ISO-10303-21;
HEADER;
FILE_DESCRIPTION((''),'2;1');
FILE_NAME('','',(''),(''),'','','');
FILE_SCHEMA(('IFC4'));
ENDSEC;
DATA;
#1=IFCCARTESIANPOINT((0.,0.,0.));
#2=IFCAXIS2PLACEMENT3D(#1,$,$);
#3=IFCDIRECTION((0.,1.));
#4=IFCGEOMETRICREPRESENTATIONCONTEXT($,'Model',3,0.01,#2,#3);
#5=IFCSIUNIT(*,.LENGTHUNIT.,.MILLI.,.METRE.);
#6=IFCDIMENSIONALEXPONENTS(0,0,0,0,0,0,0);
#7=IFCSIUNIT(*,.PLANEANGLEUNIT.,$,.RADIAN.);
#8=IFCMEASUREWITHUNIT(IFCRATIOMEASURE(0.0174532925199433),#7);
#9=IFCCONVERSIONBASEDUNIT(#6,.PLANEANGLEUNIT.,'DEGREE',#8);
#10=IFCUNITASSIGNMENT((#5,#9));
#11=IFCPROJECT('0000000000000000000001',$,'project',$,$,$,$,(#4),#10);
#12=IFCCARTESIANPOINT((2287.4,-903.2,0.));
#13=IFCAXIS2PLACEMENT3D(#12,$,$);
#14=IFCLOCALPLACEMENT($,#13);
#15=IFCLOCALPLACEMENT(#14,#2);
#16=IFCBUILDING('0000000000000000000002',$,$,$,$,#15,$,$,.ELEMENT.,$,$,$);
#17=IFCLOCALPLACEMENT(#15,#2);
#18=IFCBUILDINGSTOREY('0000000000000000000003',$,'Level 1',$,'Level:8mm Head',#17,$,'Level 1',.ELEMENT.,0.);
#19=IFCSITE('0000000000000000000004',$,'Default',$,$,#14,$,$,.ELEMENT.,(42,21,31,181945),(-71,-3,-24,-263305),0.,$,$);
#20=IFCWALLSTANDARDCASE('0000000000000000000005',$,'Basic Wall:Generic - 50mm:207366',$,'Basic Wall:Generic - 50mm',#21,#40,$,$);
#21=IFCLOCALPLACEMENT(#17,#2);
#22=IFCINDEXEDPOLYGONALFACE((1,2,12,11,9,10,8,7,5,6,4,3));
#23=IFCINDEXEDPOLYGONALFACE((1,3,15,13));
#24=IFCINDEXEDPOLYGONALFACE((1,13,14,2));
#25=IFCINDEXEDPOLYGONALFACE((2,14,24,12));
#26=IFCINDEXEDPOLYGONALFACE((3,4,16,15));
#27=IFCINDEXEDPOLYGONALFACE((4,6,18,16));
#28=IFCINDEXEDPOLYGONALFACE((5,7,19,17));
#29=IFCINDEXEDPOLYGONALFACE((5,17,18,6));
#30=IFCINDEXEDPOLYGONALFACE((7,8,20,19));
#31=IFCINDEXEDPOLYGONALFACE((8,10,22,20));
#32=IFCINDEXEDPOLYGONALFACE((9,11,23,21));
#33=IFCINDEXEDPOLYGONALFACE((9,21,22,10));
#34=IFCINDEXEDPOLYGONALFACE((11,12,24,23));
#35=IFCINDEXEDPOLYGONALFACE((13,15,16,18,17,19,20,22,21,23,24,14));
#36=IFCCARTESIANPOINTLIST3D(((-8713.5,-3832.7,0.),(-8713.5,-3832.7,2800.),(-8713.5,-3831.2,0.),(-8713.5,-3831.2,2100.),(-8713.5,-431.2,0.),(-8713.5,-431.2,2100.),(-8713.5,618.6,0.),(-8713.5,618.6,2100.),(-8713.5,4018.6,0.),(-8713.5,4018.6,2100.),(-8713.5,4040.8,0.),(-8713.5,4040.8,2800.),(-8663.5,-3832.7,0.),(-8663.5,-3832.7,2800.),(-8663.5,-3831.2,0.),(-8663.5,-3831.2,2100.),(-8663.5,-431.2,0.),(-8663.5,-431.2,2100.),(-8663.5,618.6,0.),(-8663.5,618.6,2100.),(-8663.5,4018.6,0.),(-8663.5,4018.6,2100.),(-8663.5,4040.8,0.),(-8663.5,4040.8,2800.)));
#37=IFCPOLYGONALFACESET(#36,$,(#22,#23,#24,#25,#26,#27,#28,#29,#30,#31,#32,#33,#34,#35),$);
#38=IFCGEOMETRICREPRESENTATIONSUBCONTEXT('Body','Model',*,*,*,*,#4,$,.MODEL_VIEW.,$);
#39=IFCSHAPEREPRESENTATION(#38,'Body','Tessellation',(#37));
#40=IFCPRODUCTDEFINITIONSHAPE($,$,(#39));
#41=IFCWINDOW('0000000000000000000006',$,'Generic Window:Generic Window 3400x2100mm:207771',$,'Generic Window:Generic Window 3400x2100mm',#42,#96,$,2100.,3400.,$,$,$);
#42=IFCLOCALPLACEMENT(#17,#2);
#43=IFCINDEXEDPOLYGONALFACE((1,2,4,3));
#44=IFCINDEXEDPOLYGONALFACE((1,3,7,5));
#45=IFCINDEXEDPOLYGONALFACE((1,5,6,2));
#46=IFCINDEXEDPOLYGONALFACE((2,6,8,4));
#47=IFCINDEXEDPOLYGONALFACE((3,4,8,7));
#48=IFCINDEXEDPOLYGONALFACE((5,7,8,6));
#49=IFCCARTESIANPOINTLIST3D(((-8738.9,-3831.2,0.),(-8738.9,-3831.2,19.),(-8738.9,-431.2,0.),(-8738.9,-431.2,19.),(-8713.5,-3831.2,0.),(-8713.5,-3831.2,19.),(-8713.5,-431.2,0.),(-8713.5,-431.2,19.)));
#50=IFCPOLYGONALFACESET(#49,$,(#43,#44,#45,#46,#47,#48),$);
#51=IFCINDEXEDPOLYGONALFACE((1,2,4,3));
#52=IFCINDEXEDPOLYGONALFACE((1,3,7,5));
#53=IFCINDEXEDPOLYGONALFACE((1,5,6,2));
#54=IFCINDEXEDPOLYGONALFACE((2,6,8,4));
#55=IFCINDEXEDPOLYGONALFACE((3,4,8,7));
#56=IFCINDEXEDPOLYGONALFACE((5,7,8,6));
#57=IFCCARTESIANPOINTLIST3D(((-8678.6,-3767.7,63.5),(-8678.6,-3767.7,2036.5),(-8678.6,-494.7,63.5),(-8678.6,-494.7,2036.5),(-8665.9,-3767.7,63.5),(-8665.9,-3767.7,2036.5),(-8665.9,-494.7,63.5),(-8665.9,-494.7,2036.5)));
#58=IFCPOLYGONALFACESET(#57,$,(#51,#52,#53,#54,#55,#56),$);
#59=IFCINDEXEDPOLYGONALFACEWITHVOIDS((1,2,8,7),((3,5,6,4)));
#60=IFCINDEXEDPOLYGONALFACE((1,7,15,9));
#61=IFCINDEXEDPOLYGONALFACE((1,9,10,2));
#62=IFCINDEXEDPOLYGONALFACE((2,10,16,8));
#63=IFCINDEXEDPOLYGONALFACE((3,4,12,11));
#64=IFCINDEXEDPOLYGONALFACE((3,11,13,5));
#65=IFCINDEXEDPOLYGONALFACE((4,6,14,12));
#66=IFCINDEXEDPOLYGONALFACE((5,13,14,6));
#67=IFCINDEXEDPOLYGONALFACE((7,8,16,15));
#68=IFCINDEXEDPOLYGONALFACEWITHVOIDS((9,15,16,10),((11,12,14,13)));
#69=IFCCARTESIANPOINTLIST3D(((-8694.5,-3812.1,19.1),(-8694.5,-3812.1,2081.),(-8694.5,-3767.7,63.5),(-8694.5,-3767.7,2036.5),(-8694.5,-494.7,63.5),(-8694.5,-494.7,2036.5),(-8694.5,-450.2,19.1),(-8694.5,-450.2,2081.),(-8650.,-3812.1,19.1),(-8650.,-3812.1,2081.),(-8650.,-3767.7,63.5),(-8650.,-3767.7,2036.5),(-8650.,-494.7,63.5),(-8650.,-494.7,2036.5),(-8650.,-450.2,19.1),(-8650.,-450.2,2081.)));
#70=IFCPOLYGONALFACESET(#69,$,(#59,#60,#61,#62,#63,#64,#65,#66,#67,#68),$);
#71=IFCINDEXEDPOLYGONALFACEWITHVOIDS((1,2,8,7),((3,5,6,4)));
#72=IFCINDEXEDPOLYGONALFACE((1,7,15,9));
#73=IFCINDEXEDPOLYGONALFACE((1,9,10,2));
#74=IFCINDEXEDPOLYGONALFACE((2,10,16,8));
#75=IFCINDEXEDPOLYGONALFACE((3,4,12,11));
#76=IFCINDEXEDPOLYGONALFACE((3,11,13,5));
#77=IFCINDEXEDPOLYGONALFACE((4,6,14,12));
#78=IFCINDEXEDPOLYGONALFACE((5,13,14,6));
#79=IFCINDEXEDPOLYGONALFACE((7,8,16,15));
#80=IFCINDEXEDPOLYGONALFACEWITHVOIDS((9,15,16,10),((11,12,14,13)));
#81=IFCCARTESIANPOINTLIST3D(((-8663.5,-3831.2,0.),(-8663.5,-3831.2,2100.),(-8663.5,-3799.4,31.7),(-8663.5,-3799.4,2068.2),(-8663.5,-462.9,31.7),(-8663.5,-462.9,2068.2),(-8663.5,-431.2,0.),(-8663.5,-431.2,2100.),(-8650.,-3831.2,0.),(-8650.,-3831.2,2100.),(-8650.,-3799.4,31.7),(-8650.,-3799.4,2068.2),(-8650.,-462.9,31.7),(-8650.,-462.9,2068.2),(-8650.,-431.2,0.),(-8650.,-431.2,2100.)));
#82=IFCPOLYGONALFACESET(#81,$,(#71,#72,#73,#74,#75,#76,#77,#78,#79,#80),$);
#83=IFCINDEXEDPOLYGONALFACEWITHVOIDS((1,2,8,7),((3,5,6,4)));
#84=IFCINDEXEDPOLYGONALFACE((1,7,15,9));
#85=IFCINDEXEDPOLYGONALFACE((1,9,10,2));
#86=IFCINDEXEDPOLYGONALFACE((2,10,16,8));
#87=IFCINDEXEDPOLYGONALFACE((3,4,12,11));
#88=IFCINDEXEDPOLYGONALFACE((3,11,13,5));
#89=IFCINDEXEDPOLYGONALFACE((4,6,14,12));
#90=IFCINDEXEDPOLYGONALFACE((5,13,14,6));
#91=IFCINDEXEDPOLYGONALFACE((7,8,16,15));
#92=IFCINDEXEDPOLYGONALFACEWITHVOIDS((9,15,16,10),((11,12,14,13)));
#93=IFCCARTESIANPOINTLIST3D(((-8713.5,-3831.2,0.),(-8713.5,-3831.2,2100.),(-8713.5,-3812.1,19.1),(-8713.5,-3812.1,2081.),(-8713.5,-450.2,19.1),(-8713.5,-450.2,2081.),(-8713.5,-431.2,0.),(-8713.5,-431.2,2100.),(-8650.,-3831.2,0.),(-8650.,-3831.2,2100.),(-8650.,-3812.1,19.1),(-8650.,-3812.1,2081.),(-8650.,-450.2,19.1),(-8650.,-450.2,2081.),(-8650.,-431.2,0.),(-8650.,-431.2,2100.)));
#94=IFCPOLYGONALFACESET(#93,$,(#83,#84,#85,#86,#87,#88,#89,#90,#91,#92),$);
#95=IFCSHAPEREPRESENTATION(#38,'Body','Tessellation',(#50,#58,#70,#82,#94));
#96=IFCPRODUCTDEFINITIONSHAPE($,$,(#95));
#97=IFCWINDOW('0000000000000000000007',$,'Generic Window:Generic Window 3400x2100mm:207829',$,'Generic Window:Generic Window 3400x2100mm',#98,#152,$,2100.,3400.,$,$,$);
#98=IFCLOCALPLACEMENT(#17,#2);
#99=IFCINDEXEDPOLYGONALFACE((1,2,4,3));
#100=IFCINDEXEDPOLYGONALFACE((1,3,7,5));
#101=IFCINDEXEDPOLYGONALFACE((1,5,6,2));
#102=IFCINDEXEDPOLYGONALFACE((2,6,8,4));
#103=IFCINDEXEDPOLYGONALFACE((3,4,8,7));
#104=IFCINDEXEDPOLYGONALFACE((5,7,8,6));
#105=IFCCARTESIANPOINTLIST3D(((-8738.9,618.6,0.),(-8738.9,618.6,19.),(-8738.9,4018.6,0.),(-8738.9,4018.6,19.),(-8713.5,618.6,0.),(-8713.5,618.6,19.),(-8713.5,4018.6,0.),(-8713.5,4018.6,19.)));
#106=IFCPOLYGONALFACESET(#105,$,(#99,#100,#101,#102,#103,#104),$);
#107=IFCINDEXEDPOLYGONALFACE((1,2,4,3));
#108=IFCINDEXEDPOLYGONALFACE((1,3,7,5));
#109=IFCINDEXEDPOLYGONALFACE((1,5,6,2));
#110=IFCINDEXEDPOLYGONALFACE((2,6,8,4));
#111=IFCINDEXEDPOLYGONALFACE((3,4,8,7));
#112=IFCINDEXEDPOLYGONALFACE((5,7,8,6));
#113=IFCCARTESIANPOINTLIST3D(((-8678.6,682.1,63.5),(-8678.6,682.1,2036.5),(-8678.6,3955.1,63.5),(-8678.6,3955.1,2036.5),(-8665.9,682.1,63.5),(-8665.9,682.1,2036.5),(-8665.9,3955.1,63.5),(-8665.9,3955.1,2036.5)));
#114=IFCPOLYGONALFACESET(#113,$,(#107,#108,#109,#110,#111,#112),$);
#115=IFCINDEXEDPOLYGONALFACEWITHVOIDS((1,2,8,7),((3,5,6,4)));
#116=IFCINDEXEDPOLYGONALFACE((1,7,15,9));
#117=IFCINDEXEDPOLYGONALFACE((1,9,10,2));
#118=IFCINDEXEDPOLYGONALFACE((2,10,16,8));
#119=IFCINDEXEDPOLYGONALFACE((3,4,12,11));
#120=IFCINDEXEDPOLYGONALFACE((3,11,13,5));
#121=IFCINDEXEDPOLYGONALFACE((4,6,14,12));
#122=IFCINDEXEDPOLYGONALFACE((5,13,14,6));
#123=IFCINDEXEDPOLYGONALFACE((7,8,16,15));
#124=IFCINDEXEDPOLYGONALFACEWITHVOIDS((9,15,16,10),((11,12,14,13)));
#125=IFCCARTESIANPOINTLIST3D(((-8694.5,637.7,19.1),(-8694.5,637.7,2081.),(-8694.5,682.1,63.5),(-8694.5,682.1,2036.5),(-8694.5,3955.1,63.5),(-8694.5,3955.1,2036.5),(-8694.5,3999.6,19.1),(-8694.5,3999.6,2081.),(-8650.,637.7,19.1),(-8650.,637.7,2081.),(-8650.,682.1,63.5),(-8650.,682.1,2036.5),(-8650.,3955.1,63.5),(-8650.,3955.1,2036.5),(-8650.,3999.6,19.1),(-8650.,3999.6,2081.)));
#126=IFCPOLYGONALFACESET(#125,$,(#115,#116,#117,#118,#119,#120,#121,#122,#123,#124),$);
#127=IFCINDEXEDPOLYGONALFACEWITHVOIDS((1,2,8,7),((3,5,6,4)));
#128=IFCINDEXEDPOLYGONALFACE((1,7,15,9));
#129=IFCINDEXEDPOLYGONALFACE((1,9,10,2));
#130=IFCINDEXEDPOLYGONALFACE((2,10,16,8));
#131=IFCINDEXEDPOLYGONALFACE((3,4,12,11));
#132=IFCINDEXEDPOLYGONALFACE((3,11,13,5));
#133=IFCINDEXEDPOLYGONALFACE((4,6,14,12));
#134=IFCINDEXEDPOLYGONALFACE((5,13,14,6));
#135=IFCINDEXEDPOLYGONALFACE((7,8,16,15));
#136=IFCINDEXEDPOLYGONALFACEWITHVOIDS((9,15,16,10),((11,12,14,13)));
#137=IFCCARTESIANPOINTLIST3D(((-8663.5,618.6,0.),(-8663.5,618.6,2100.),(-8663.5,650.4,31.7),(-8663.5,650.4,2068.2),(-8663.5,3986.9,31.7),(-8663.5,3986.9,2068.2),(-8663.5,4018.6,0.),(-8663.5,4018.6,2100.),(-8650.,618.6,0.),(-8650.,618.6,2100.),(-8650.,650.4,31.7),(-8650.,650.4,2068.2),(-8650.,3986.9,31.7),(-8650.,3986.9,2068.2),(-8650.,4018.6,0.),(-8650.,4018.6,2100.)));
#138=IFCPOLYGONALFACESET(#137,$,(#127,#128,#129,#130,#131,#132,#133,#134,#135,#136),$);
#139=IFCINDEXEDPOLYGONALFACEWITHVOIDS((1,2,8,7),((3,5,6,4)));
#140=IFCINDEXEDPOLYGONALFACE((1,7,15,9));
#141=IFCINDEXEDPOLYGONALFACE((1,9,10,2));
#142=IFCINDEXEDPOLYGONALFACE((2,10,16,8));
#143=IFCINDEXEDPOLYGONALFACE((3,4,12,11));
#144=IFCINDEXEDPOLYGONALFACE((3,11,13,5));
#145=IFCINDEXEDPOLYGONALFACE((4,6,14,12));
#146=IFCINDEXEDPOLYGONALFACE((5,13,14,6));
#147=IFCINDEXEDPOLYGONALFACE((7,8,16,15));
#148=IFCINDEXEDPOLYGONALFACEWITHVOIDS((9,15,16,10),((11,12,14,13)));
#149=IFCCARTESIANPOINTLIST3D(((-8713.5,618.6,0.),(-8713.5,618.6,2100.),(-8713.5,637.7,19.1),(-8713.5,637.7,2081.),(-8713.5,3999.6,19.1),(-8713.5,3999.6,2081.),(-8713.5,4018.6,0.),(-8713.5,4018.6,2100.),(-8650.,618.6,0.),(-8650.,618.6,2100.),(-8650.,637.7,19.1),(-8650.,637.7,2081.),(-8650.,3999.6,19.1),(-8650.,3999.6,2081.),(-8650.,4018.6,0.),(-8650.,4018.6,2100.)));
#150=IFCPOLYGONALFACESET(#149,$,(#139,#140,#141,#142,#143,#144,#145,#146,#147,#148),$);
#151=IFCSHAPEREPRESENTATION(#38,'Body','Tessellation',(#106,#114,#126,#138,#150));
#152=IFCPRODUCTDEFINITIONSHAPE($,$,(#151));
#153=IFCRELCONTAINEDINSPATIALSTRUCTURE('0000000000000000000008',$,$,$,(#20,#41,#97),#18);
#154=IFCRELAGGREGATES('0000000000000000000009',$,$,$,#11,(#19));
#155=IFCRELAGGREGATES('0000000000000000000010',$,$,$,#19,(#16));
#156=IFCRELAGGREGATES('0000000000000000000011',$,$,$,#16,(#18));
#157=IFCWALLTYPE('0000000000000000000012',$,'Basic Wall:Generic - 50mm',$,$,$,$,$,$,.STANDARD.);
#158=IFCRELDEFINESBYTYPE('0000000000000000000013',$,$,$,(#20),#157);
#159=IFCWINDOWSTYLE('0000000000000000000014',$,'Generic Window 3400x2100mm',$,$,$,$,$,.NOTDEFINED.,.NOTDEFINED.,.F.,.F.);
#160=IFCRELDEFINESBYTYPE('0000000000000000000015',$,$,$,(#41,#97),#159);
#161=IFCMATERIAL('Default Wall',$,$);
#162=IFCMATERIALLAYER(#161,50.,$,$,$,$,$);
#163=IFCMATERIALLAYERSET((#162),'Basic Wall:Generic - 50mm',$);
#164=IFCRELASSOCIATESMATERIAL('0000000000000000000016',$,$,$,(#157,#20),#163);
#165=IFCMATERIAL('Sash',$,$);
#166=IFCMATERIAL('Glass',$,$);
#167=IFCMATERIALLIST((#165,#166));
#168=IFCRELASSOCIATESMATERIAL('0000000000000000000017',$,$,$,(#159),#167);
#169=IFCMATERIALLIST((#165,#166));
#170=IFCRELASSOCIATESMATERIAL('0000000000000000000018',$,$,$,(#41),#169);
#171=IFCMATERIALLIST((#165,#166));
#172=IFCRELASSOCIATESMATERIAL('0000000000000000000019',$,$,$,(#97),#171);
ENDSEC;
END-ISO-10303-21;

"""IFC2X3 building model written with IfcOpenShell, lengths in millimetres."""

from ifc_helpers import new_model, entity, si_unit, converted_unit, direction, frame, frame_2d, origin, origin_2d_with_axis, place, context, subcontext, project, spatial, polyline, rectangle, outline, extrude, source, transform, mapped, material, material_list, layer, layer_set, layer_usage, type_object, type_shapes, element, fill, save


model = new_model("IFC2X3")

# Units and contexts
model_context = context("Model", 3, precision=0.01, world=origin(), true_north=direction((0.0, 1.0)))
body_context = subcontext(model_context, "Body", "Model", "MODEL_VIEW")
ifc_project = project(units=[si_unit("LENGTHUNIT", "METRE", prefix="MILLI"), converted_unit("PLANEANGLEUNIT", "DEGREE", entity("IfcRatioMeasure", 0.0174532925199433), si_unit("PLANEANGLEUNIT", "RADIAN"), dimensions=[0, 0, 0, 0, 0, 0, 0])], contexts=[model_context])

# Site, building, storey
site_placement = place(None, frame((2287.4, -903.2, 0.0)))
site = spatial("IfcSite", under=ifc_project, at=site_placement, Name="Default", CompositionType="ELEMENT", RefLatitude=(42, 21, 31, 181945), RefLongitude=(-71, -3, -24, -263305), RefElevation=0.0)
building_placement = place(site_placement, origin())
building = spatial("IfcBuilding", under=site, at=building_placement, CompositionType="ELEMENT")
storey_placement = place(building_placement, origin())
storey = spatial("IfcBuildingStorey", under=building, at=storey_placement, Name="Level 1", ObjectType="Level:8mm Head", LongName="Level 1", CompositionType="ELEMENT", Elevation=0.0)

# Shared definitions
ifc_material_1 = material(Name="Default Wall")
ifc_layer = layer(ifc_material_1, 50.0)
ifc_layer_set = layer_set([ifc_layer], Name="Basic Wall:Generic - 50mm")
wall_type = type_object("IfcWallType", Name="Basic Wall:Generic - 50mm", PredefinedType="STANDARD", material=ifc_layer_set)

# Wall, openings, windows
ifc_layer_usage_1 = layer_usage(ifc_layer_set, "AXIS2", "POSITIVE", -25.0)
wall_1_placement = place(storey_placement, frame((-8688.5, 4040.8, 0.0), z_axis=(0.0, 0.0, 1.0), x_axis=(0.0, -1.0, 0.0)))
wall_1 = element("IfcWallStandardCase", 1, at=wall_1_placement, inside=storey, type_object=wall_type, material=ifc_layer_usage_1, Name="Basic Wall:Generic - 50mm:207366", ObjectType="Basic Wall:Generic - 50mm", context=body_context, shape_type="SweptSolid", body=[
    extrude(rectangle(XDim=7873.5, YDim=50.0, at=frame_2d((3936.8, 0.0), x_axis=(-1.0, 0.0))), origin(), (0.0, 0.0, 1.0), 2800.0),
])
opening_1_placement = place(wall_1_placement, frame((7872.0, 25.0, 0.0)))
opening_1 = element("IfcOpeningElement", 2, at=opening_1_placement, cuts=wall_1, ObjectType="Opening", context=body_context, shape_type="SweptSolid", body=[
    extrude(rectangle(XDim=2100.0, YDim=3400.0, at=frame_2d((1050.0, 1700.0), x_axis=(-1.0, 0.0))), frame((0.0, 0.0, 0.0), z_axis=(0.0, -1.0, 0.0), x_axis=(0.0, 0.0, 1.0)), (0.0, 0.0, 1.0), 50.0),
])
opening_2_placement = place(wall_1_placement, frame((3422.2, 25.0, 0.0)))
opening_2 = element("IfcOpeningElement", 3, at=opening_2_placement, cuts=wall_1, ObjectType="Opening", context=body_context, shape_type="SweptSolid", body=[
    extrude(rectangle(XDim=2100.0, YDim=3400.0, at=frame_2d((1050.0, 1700.0), x_axis=(-1.0, 0.0))), frame((0.0, 0.0, 0.0), z_axis=(0.0, -1.0, 0.0), x_axis=(0.0, 0.0, 1.0)), (0.0, 0.0, 1.0), 50.0),
])
ifc_material_2 = material(Name="Sash")
ifc_material_3 = material(Name="Glass")
ifc_material_list_1 = material_list([ifc_material_2, ifc_material_3])
ifc_material_list_2 = material_list([ifc_material_2, ifc_material_3])
window_style = type_object("IfcWindowStyle", Name="Generic Window 3400x2100mm", ConstructionType="NOTDEFINED", OperationType="NOTDEFINED", ParameterTakesPrecedence=False, Sizeable=False, material=ifc_material_list_2)
shared_shape = source(origin(), body_context, "Body", "SweptSolid", [
    extrude(rectangle(XDim=25.4, YDim=3400.0, at=origin_2d_with_axis()), frame((1700.0, 62.7, 0.0), z_axis=(0.0, 0.0, 1.0), x_axis=(0.0, -1.0, 0.0)), (0.0, 0.0, 1.0), 19.0),
    extrude(rectangle(XDim=12.7, YDim=3273.0, at=origin_2d_with_axis()), frame((1700.0, 8.8, 63.5), z_axis=(0.0, 0.0, 1.0), x_axis=(0.0, 1.0, 0.0)), (0.0, 0.0, 1.0), 1973.0),
    extrude(outline(polyline([(-1681.0, -1031.0), (1681.0, -1031.0), (1681.0, 1031.0), (-1681.0, 1031.0), (-1681.0, -1031.0)]), holes=[polyline([(-1636.5, -986.5), (-1636.5, 986.5), (1636.5, 986.5), (1636.5, -986.5), (-1636.5, -986.5)])]), frame((1700.0, -13.4, 1050.0), z_axis=(0.0, 1.0, 0.0), x_axis=(1.0, 0.0, 0.0)), (0.0, 0.0, 1.0), 44.5),
    extrude(outline(polyline([(-1700.0, -1050.0), (1700.0, -1050.0), (1700.0, 1050.0), (-1700.0, 1050.0), (-1700.0, -1050.0)]), holes=[polyline([(-1668.2, -1018.2), (-1668.2, 1018.3), (1668.2, 1018.3), (1668.2, -1018.2), (-1668.2, -1018.2)])]), frame((1700.0, -13.4, 1050.0), z_axis=(0.0, 1.0, 0.0), x_axis=(1.0, 0.0, 0.0)), (0.0, 0.0, 1.0), 13.4),
    extrude(outline(polyline([(-1050.0, -1700.0), (1050.0, -1700.0), (1050.0, 1700.0), (-1050.0, 1700.0), (-1050.0, -1700.0)]), holes=[polyline([(-1031.0, -1681.0), (-1031.0, 1681.0), (1031.0, 1681.0), (1031.0, -1681.0), (-1031.0, -1681.0)])]), frame((1700.0, -13.4, 1050.0), z_axis=(0.0, 1.0, 0.0), x_axis=(0.0, 0.0, -1.0)), (0.0, 0.0, 1.0), 63.5),
])
type_shapes(window_style, [shared_shape])
window_1_placement = place(opening_1_placement, frame((0.0, 0.0, 0.0), z_axis=(0.0, 0.0, 1.0), x_axis=(-1.0, 0.0, 0.0)))
window_1 = element("IfcWindow", 4, at=window_1_placement, inside=storey, type_object=window_style, material=ifc_material_list_1, Name="Generic Window:Generic Window 3400x2100mm:207771", ObjectType="Generic Window:Generic Window 3400x2100mm", OverallHeight=2100.0, OverallWidth=3400.0, context=body_context, shape_type="MappedRepresentation", body=[
    mapped(shared_shape, transform((0.0, 0.0, 0.0), scale=1.0)),
])
fill(opening_1, window_1)
ifc_material_list_3 = material_list([ifc_material_2, ifc_material_3])
window_2_placement = place(opening_2_placement, frame((0.0, 0.0, 0.0), z_axis=(0.0, 0.0, 1.0), x_axis=(-1.0, 0.0, 0.0)))
window_2 = element("IfcWindow", 5, at=window_2_placement, inside=storey, type_object=window_style, material=ifc_material_list_3, Name="Generic Window:Generic Window 3400x2100mm:207829", ObjectType="Generic Window:Generic Window 3400x2100mm", OverallHeight=2100.0, OverallWidth=3400.0, context=body_context, shape_type="MappedRepresentation", body=[
    mapped(shared_shape, transform((0.0, 0.0, 0.0), scale=1.0)),
])
fill(opening_2, window_2)

save(model, "model.ifc")
